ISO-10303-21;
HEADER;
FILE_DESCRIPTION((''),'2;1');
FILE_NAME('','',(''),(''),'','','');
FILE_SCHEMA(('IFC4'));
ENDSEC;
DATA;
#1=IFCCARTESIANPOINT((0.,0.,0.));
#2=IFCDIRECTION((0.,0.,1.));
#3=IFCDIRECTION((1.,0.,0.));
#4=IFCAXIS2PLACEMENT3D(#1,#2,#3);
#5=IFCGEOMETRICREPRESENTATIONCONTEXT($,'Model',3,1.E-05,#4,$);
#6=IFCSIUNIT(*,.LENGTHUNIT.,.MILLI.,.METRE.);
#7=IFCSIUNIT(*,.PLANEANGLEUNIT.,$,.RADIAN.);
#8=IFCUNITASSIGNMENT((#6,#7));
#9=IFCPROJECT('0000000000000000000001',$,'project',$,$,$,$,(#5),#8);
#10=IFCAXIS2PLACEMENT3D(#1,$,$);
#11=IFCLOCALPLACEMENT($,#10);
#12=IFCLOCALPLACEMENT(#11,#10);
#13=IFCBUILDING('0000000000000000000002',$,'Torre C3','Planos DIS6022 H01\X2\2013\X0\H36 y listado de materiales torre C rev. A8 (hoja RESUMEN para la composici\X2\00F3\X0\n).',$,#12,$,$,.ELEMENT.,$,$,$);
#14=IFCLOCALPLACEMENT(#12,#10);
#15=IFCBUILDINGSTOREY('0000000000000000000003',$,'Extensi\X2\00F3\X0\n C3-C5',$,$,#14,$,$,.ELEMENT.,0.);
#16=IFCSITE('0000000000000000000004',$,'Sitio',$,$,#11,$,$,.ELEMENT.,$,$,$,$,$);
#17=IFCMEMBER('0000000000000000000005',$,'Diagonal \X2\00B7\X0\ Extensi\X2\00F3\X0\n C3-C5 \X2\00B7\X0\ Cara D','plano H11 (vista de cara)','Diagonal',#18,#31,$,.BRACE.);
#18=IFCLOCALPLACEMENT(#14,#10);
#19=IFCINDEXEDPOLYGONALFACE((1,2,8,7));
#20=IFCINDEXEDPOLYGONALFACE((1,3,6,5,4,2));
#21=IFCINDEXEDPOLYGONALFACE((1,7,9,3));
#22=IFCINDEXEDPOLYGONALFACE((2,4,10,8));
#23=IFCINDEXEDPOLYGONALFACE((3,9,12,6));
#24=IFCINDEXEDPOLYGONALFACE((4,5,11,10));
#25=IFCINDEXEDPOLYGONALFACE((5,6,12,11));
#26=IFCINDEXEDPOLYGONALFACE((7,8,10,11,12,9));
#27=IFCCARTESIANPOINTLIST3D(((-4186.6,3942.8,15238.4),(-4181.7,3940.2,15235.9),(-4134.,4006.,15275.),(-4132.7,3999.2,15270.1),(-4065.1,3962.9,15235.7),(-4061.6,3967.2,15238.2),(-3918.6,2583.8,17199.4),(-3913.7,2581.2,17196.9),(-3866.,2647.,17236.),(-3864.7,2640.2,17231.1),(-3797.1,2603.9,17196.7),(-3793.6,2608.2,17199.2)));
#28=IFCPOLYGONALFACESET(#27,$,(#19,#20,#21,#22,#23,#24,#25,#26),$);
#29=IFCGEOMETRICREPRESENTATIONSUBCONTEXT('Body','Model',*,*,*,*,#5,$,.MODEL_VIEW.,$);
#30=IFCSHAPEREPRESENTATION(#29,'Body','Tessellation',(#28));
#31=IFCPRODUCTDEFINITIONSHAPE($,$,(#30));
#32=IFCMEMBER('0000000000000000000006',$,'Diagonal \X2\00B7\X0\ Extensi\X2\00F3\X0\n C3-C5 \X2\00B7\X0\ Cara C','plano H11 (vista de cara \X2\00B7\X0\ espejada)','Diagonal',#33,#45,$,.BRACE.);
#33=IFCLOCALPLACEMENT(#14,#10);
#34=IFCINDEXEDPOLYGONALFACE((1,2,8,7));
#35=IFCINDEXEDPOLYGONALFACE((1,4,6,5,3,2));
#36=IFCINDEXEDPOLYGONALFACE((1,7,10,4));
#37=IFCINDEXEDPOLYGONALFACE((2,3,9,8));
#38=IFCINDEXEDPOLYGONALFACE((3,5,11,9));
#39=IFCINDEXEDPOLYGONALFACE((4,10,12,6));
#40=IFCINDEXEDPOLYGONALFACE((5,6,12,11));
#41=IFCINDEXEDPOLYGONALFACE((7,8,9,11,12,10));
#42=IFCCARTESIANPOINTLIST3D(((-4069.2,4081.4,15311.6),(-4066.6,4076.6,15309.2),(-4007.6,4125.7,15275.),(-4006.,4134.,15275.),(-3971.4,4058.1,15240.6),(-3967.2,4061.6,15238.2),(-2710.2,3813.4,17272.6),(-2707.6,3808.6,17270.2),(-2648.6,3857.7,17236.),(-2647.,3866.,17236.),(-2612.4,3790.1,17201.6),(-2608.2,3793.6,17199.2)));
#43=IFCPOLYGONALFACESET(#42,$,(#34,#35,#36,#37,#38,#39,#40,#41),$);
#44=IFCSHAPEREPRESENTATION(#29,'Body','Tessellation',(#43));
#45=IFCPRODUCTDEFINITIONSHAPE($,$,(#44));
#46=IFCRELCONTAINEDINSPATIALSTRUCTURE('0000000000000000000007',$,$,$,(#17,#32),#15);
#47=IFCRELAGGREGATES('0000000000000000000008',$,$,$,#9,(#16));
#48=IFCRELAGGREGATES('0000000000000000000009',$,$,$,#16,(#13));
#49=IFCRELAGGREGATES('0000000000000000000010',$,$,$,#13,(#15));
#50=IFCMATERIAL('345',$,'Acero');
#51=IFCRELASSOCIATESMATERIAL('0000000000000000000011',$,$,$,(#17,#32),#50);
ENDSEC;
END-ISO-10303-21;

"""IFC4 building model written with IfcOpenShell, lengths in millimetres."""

from ifc_helpers import new_model, si_unit, frame, frame_2d, origin, origin_with_axes, place, context, subcontext, project, spatial, l_section, extrude, material, element, save


model = new_model("IFC4")

# Units and contexts
model_context = context("Model", 3, precision=1e-05, world=origin_with_axes())
body_context = subcontext(model_context, "Body", "Model", "MODEL_VIEW")
ifc_project = project(units=[si_unit("LENGTHUNIT", "METRE", prefix="MILLI"), si_unit("PLANEANGLEUNIT", "RADIAN")], contexts=[model_context])

# Site, building, storey
site_placement = place(None, origin())
site = spatial("IfcSite", under=ifc_project, at=site_placement, Name="Sitio", CompositionType="ELEMENT")
building_placement = place(site_placement, origin())
building = spatial("IfcBuilding", under=site, at=building_placement, Name="Torre C3", Description="Planos DIS6022 H01–H36 y listado de materiales torre C rev. A8 (hoja RESUMEN para la composición).", CompositionType="ELEMENT")
storey_placement = place(building_placement, origin())
storey = spatial("IfcBuildingStorey", under=building, at=storey_placement, Name="Extensión C3-C5", CompositionType="ELEMENT", Elevation=0.0)

# Members
ifc_material_1 = material(Name="345", Category="Acero")
for number, where, z_axis, x_axis, name, description in (
    (1, (-3866.0, 2647.0, 17236.0), (-0.111626, 0.566042, -0.816784), (0.803983, -0.431647, -0.409013), "Diagonal · Extensión C3-C5 · Cara D", "plano H11 (vista de cara)"),
    (2, (-2647.0, 3866.0, 17236.0), (-0.566042, 0.111626, -0.816784), (0.431647, -0.803983, -0.409013), "Diagonal · Extensión C3-C5 · Cara C", "plano H11 (vista de cara · espejada)"),
):
    element("IfcMember", number, at=place(storey_placement, frame(where, z_axis=z_axis, x_axis=x_axis)), inside=storey, material=ifc_material_1, Name=name, Description=description, ObjectType="Diagonal", PredefinedType="BRACE", context=body_context, shape_type="SweptSolid", body=[
        extrude(l_section(Depth=90.0, Width=90.0, Thickness=6.0, at=frame_2d((45.0, 45.0))), None, (0.0, 0.0, 1.0), 2400.9),
    ])

save(model, "model.ifc")
